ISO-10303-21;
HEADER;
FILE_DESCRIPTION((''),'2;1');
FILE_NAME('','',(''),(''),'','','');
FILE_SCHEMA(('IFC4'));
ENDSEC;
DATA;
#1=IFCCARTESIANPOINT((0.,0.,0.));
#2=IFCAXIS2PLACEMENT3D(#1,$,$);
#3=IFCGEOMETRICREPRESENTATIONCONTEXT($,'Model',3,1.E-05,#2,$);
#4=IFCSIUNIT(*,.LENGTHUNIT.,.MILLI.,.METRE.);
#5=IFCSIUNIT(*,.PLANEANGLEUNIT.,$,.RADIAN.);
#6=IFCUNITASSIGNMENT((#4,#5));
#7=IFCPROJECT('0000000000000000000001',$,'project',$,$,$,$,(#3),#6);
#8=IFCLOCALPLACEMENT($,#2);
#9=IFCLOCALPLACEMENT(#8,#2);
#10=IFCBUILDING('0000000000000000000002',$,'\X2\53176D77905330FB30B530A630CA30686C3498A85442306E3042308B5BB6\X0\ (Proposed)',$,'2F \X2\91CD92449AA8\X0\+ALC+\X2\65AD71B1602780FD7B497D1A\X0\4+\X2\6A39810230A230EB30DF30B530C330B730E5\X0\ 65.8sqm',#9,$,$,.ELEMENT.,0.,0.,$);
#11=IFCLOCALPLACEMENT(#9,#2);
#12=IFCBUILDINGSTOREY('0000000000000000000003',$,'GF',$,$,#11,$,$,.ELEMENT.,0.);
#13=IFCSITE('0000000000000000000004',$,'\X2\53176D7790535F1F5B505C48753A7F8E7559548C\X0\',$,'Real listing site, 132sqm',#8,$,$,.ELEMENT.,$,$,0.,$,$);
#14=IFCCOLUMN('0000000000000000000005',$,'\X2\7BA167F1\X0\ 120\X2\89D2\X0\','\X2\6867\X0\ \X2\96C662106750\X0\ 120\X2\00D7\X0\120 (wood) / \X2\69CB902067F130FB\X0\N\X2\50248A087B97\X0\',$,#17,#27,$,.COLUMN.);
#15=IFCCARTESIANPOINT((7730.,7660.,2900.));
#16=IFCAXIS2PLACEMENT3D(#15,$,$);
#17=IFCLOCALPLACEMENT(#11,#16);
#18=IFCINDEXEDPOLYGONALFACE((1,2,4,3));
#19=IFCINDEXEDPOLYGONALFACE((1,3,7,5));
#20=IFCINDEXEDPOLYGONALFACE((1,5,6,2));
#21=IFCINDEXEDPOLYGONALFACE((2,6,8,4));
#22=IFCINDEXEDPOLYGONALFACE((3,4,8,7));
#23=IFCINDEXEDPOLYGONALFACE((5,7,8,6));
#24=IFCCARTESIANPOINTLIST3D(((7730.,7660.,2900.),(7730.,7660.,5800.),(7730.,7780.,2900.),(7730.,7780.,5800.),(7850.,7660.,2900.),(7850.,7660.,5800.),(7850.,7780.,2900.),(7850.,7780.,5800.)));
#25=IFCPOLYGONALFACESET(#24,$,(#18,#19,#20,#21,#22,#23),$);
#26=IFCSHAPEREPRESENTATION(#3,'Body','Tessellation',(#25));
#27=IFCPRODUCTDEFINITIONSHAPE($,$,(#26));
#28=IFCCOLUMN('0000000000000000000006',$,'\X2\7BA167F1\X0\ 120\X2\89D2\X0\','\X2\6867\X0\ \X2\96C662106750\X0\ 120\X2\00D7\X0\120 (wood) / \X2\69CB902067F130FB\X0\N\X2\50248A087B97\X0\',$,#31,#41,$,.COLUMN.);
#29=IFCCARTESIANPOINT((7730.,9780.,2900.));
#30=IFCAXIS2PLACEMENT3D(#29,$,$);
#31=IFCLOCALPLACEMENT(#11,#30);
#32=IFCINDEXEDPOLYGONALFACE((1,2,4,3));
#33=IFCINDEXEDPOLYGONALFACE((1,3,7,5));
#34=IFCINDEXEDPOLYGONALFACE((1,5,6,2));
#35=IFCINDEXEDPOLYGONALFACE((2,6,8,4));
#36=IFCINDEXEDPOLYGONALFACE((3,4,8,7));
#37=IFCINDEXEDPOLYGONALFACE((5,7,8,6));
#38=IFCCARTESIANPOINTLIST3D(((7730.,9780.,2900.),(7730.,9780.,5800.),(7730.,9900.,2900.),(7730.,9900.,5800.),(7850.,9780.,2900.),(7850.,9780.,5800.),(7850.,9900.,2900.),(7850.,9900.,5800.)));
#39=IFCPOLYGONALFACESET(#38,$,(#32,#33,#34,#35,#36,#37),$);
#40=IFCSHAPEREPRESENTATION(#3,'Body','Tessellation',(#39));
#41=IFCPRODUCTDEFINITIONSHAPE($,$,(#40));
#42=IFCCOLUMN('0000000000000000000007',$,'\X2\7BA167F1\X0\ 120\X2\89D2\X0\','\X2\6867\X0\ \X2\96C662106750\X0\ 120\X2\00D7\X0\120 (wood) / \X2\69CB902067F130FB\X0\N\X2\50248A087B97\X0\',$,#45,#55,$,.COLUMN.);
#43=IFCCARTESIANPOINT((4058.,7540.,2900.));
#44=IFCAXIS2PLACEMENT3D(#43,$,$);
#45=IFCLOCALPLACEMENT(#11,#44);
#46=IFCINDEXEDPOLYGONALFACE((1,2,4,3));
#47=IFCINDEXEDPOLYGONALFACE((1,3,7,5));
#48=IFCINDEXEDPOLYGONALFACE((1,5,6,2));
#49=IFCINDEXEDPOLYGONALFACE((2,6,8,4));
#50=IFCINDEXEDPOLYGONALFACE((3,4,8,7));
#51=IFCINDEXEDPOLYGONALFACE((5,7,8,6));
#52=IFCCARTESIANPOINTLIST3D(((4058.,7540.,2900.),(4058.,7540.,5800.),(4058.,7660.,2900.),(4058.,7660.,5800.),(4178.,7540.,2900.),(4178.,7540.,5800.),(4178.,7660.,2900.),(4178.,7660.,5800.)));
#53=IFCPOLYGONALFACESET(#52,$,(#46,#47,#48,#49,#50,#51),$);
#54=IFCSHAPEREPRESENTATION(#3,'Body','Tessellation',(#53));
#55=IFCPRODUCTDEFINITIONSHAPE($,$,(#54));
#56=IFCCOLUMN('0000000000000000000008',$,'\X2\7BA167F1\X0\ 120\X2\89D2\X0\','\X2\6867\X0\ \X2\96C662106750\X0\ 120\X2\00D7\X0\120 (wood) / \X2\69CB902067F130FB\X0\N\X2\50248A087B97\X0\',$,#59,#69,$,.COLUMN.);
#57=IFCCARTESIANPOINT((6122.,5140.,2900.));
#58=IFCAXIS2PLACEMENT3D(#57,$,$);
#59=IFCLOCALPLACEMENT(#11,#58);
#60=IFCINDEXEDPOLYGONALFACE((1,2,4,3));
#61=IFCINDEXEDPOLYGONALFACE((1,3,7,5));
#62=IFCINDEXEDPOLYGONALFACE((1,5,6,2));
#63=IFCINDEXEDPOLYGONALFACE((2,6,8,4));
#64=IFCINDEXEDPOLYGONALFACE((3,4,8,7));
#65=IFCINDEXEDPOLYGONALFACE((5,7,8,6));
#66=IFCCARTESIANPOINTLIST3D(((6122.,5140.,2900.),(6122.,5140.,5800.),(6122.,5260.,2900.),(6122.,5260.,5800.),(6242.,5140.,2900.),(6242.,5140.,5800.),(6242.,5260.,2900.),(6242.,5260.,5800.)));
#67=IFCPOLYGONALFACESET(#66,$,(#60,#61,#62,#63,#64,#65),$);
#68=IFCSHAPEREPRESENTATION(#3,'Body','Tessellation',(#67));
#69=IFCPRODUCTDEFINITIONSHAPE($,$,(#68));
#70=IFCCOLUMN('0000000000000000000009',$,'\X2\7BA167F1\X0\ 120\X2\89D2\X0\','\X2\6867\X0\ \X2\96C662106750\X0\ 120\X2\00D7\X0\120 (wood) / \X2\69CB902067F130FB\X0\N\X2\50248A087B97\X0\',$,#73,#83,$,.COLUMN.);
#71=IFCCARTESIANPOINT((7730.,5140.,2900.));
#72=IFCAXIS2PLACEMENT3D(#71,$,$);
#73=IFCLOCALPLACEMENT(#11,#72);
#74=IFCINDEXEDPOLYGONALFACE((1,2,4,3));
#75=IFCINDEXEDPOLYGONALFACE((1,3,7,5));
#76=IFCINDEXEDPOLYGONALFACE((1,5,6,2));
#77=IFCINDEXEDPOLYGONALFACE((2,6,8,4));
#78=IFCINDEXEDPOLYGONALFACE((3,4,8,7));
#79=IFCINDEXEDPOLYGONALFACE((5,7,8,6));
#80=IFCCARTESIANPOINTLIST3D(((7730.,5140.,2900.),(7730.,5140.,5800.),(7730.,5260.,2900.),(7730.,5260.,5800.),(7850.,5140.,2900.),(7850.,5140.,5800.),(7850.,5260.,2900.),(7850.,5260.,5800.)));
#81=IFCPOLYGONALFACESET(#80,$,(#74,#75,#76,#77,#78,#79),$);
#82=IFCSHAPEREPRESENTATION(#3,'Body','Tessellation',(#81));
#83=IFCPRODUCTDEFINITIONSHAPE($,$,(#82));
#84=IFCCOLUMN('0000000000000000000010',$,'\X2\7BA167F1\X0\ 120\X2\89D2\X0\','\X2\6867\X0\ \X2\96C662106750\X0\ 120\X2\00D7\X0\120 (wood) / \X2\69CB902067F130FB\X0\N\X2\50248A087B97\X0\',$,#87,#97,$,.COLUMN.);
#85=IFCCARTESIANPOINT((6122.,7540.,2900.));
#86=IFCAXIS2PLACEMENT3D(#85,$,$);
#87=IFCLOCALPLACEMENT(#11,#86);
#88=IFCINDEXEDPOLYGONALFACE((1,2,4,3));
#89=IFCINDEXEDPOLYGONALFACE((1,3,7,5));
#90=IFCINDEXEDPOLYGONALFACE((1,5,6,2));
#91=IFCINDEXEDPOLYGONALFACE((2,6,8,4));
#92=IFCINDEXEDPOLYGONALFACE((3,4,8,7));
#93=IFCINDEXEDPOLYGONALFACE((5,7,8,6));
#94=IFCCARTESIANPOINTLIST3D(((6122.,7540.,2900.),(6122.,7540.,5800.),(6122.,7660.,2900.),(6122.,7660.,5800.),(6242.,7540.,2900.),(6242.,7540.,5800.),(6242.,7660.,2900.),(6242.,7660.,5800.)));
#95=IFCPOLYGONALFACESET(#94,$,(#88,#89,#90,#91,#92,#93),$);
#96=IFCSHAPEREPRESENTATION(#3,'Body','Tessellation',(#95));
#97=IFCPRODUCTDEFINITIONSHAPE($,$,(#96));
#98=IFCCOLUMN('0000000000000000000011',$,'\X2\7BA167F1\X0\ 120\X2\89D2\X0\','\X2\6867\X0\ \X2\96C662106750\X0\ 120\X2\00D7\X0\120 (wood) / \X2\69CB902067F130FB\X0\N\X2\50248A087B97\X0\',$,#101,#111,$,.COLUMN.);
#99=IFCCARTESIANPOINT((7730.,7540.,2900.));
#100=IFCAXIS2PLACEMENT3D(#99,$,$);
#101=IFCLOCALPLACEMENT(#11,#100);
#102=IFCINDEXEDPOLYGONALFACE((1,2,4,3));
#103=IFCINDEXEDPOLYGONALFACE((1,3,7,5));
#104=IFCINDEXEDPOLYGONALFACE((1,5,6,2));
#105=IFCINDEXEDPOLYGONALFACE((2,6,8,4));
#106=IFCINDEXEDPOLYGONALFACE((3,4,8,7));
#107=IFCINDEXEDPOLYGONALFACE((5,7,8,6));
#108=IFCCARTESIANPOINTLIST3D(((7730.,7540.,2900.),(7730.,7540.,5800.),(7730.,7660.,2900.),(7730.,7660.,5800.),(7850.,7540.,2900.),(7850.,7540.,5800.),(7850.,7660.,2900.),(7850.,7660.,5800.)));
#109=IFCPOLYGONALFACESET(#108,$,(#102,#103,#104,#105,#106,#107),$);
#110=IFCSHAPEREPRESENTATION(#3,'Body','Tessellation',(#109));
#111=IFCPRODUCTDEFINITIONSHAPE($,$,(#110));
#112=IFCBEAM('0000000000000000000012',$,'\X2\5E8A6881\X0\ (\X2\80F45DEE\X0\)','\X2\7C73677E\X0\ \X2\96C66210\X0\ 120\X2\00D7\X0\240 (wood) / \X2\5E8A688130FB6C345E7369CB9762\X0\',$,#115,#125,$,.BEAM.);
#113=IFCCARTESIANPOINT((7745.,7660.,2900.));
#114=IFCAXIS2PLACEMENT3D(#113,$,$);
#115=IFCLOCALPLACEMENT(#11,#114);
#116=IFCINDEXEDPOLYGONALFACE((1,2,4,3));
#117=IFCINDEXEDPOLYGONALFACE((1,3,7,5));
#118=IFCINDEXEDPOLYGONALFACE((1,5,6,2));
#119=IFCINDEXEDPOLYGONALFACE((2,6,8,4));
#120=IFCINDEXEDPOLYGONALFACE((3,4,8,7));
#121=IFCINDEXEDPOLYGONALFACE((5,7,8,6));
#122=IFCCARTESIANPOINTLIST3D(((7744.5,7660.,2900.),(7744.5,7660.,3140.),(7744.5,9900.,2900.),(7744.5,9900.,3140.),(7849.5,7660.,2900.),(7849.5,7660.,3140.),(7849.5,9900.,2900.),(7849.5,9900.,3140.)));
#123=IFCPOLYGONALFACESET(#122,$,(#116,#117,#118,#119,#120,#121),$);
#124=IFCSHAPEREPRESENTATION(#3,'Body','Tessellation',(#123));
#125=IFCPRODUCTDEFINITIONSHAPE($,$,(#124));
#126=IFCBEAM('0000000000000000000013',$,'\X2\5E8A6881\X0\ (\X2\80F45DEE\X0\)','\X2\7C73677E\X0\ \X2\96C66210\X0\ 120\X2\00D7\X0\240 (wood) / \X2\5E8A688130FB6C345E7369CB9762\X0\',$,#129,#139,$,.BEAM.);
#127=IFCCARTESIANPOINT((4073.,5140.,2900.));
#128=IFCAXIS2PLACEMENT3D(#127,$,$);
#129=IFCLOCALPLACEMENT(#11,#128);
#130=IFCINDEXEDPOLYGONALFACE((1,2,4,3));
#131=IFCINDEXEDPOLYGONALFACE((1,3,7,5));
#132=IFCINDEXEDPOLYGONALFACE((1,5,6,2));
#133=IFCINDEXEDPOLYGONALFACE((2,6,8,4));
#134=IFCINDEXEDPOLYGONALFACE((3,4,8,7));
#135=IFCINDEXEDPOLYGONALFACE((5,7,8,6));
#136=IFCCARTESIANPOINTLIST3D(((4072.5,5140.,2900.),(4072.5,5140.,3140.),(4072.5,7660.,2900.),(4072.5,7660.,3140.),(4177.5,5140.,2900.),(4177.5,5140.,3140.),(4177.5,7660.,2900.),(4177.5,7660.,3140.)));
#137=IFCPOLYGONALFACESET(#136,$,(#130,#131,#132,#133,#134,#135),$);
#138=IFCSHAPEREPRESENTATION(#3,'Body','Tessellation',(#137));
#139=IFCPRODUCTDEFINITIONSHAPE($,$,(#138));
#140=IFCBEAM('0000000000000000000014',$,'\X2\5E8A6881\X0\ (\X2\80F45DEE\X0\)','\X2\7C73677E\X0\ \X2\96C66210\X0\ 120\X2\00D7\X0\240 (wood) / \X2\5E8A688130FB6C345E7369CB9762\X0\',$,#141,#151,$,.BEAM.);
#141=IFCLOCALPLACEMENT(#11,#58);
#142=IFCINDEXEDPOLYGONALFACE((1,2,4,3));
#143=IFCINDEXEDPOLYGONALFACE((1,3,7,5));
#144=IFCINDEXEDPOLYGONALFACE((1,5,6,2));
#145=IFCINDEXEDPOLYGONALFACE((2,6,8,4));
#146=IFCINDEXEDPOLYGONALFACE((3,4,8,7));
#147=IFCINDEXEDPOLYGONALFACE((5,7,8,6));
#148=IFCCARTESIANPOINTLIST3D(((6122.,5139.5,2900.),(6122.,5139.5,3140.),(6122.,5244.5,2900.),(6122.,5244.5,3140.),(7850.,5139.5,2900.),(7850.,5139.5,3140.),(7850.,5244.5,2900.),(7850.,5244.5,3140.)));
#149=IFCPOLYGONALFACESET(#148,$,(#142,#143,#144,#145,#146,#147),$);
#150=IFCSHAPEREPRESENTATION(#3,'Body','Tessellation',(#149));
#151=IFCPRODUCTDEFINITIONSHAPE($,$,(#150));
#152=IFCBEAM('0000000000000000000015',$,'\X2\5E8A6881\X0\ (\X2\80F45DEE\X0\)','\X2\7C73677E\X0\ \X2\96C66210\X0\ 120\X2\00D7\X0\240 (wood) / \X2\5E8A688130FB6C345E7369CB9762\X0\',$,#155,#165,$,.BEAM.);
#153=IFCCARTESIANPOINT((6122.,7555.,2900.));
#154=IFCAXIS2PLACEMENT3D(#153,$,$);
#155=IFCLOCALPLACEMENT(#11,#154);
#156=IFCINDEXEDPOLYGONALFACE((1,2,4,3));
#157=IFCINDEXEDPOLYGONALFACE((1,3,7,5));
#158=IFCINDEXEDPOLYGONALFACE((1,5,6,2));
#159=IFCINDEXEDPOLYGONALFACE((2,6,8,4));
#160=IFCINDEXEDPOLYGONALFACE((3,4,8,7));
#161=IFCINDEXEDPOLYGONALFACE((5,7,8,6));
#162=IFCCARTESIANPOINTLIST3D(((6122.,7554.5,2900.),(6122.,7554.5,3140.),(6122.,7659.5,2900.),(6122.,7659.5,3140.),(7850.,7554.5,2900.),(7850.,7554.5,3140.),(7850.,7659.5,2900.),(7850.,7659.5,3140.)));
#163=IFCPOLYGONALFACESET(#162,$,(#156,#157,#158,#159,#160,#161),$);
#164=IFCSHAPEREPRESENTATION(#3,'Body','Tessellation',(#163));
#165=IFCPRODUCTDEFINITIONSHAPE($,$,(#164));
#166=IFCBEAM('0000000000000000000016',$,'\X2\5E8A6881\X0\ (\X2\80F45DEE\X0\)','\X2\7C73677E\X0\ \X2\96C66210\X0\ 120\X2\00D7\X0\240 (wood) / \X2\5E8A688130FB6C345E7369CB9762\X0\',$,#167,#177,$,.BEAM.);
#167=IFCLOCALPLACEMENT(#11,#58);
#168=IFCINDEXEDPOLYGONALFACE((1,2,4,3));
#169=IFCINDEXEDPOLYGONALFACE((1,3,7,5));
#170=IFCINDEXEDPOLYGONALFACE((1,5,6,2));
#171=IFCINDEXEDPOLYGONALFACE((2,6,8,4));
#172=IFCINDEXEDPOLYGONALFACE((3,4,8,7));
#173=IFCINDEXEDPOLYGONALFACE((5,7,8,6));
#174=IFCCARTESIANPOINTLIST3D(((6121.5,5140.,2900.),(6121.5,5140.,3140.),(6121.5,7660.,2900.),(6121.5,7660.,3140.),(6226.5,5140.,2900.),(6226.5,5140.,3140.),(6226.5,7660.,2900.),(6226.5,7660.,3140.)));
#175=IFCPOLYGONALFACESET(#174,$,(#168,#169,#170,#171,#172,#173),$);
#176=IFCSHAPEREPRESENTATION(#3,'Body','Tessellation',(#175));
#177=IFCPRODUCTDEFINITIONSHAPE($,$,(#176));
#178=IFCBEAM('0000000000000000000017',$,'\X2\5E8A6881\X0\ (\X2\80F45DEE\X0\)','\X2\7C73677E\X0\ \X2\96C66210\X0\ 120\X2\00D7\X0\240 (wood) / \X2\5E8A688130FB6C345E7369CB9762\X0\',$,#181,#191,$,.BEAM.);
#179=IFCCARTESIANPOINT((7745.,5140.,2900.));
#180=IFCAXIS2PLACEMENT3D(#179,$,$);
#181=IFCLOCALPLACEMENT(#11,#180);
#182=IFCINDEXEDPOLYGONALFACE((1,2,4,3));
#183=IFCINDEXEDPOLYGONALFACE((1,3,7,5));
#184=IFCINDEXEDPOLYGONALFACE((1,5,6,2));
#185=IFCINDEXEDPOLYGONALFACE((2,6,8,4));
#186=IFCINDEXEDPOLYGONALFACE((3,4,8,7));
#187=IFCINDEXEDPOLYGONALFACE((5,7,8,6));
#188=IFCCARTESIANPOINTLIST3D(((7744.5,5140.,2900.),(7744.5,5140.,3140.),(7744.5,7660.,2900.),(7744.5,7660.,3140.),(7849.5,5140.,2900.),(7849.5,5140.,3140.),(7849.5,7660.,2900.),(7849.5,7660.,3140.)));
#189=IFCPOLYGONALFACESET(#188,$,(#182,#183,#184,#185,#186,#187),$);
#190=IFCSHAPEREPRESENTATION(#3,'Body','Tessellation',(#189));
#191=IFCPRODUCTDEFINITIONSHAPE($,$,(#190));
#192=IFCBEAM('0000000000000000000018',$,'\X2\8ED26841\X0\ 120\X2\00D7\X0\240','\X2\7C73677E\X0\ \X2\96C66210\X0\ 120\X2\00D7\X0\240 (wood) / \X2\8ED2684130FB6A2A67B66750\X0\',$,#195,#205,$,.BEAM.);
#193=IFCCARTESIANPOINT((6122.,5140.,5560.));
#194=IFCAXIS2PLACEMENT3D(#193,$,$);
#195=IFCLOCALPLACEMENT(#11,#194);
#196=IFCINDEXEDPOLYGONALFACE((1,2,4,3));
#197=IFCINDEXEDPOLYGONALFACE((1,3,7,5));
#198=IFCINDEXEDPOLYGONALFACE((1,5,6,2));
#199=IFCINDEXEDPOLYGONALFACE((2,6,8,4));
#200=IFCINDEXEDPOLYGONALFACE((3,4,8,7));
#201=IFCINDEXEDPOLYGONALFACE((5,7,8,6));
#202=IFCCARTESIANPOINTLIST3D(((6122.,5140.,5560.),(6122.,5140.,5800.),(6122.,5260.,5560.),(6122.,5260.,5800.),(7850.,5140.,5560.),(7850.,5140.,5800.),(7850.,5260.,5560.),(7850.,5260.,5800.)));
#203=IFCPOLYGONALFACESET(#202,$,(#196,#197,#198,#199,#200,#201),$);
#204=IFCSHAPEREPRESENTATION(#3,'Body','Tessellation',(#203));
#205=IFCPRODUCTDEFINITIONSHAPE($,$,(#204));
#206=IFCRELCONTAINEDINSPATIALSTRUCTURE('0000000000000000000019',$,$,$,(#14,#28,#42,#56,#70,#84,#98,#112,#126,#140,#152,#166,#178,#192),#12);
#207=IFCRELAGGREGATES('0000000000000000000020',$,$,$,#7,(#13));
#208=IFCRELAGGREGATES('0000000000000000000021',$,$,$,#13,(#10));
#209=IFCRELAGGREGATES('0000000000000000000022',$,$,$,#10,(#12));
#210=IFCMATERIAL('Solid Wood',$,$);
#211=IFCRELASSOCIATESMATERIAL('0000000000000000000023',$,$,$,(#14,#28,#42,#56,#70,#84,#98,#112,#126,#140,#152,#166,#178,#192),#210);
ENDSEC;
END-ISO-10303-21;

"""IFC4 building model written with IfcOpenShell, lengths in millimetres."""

from ifc_helpers import new_model, si_unit, frame, frame_2d, origin, place, context, project, spatial, rectangle, extrude, material, element, save


model = new_model("IFC4")

# Units and contexts
model_context = context("Model", 3, precision=1e-05, world=origin())
ifc_project = project(units=[si_unit("LENGTHUNIT", "METRE", prefix="MILLI"), si_unit("PLANEANGLEUNIT", "RADIAN")], contexts=[model_context])

# Site, building, storey
site_placement = place(None, origin())
site = spatial("IfcSite", under=ifc_project, at=site_placement, Name="北海道弟子屈町美留和", ObjectType="Real listing site, 132sqm", CompositionType="ELEMENT", RefElevation=0.0)
building_placement = place(site_placement, origin())
building = spatial("IfcBuilding", under=site, at=building_placement, Name="北海道・サウナと水風呂のある家 (Proposed)", ObjectType="2F 重鉄骨+ALC+断熱性能等級4+樹脂アルミサッシュ 65.8sqm", CompositionType="ELEMENT", ElevationOfRefHeight=0.0, ElevationOfTerrain=0.0)
storey_placement = place(building_placement, origin())
storey = spatial("IfcBuildingStorey", under=building, at=storey_placement, Name="GF", CompositionType="ELEMENT", Elevation=0.0)

# Columns
ifc_material_1 = material(Name="Solid Wood")
column_1_placement = place(storey_placement, frame((7730.0, 7660.0, 2900.0)))
element("IfcColumn", 1, at=column_1_placement, inside=storey, material=ifc_material_1, Name="管柱 120角", Description="桧 集成材 120×120 (wood) / 構造柱・N値計算", PredefinedType="COLUMN", context=model_context, shape_type="SweptSolid", body=[
    extrude(rectangle(XDim=120.0, YDim=120.0, at=frame_2d((60.0, 60.0))), frame((7730.0, 7660.0, 2900.0)), (0.0, 0.0, 1.0), 2900.0),
])
column_2_placement = place(storey_placement, frame((7730.0, 9780.0, 2900.0)))
element("IfcColumn", 2, at=column_2_placement, inside=storey, material=ifc_material_1, Name="管柱 120角", Description="桧 集成材 120×120 (wood) / 構造柱・N値計算", PredefinedType="COLUMN", context=model_context, shape_type="SweptSolid", body=[
    extrude(rectangle(XDim=120.0, YDim=120.0, at=frame_2d((60.0, 60.0))), frame((7730.0, 9780.0, 2900.0)), (0.0, 0.0, 1.0), 2900.0),
])
column_3_placement = place(storey_placement, frame((4058.0, 7540.0, 2900.0)))
element("IfcColumn", 3, at=column_3_placement, inside=storey, material=ifc_material_1, Name="管柱 120角", Description="桧 集成材 120×120 (wood) / 構造柱・N値計算", PredefinedType="COLUMN", context=model_context, shape_type="SweptSolid", body=[
    extrude(rectangle(XDim=120.0, YDim=120.0, at=frame_2d((60.0, 60.0))), frame((4058.0, 7540.0, 2900.0)), (0.0, 0.0, 1.0), 2900.0),
])
column_4_placement = place(storey_placement, frame((6122.0, 5140.0, 2900.0)))
element("IfcColumn", 4, at=column_4_placement, inside=storey, material=ifc_material_1, Name="管柱 120角", Description="桧 集成材 120×120 (wood) / 構造柱・N値計算", PredefinedType="COLUMN", context=model_context, shape_type="SweptSolid", body=[
    extrude(rectangle(XDim=120.0, YDim=120.0, at=frame_2d((60.0, 60.0))), frame((6122.0, 5140.0, 2900.0)), (0.0, 0.0, 1.0), 2900.0),
])
column_5_placement = place(storey_placement, frame((7730.0, 5140.0, 2900.0)))
element("IfcColumn", 5, at=column_5_placement, inside=storey, material=ifc_material_1, Name="管柱 120角", Description="桧 集成材 120×120 (wood) / 構造柱・N値計算", PredefinedType="COLUMN", context=model_context, shape_type="SweptSolid", body=[
    extrude(rectangle(XDim=120.0, YDim=120.0, at=frame_2d((60.0, 60.0))), frame((7730.0, 5140.0, 2900.0)), (0.0, 0.0, 1.0), 2900.0),
])
column_6_placement = place(storey_placement, frame((6122.0, 7540.0, 2900.0)))
element("IfcColumn", 6, at=column_6_placement, inside=storey, material=ifc_material_1, Name="管柱 120角", Description="桧 集成材 120×120 (wood) / 構造柱・N値計算", PredefinedType="COLUMN", context=model_context, shape_type="SweptSolid", body=[
    extrude(rectangle(XDim=120.0, YDim=120.0, at=frame_2d((60.0, 60.0))), frame((6122.0, 7540.0, 2900.0)), (0.0, 0.0, 1.0), 2900.0),
])
column_7_placement = place(storey_placement, frame((7730.0, 7540.0, 2900.0)))
element("IfcColumn", 7, at=column_7_placement, inside=storey, material=ifc_material_1, Name="管柱 120角", Description="桧 集成材 120×120 (wood) / 構造柱・N値計算", PredefinedType="COLUMN", context=model_context, shape_type="SweptSolid", body=[
    extrude(rectangle(XDim=120.0, YDim=120.0, at=frame_2d((60.0, 60.0))), frame((7730.0, 7540.0, 2900.0)), (0.0, 0.0, 1.0), 2900.0),
])

# Beams
beam_1_placement = place(storey_placement, frame((7745.0, 7660.0, 2900.0)))
element("IfcBeam", 8, at=beam_1_placement, inside=storey, material=ifc_material_1, Name="床梁 (胴差)", Description="米松 集成 120×240 (wood) / 床梁・水平構面", PredefinedType="BEAM", context=model_context, shape_type="SweptSolid", body=[
    extrude(rectangle(XDim=105.0, YDim=2240.0, at=frame_2d((52.0, 1120.0))), frame((7745.0, 7660.0, 2900.0)), (0.0, 0.0, 1.0), 240.0),
])
beam_2_placement = place(storey_placement, frame((4073.0, 5140.0, 2900.0)))
element("IfcBeam", 9, at=beam_2_placement, inside=storey, material=ifc_material_1, Name="床梁 (胴差)", Description="米松 集成 120×240 (wood) / 床梁・水平構面", PredefinedType="BEAM", context=model_context, shape_type="SweptSolid", body=[
    extrude(rectangle(XDim=105.0, YDim=2520.0, at=frame_2d((52.0, 1260.0))), frame((4073.0, 5140.0, 2900.0)), (0.0, 0.0, 1.0), 240.0),
])
beam_3_placement = place(storey_placement, frame((6122.0, 5140.0, 2900.0)))
element("IfcBeam", 10, at=beam_3_placement, inside=storey, material=ifc_material_1, Name="床梁 (胴差)", Description="米松 集成 120×240 (wood) / 床梁・水平構面", PredefinedType="BEAM", context=model_context, shape_type="SweptSolid", body=[
    extrude(rectangle(XDim=1728.0, YDim=105.0, at=frame_2d((864.0, 52.0))), frame((6122.0, 5140.0, 2900.0)), (0.0, 0.0, 1.0), 240.0),
])
beam_4_placement = place(storey_placement, frame((6122.0, 7555.0, 2900.0)))
element("IfcBeam", 11, at=beam_4_placement, inside=storey, material=ifc_material_1, Name="床梁 (胴差)", Description="米松 集成 120×240 (wood) / 床梁・水平構面", PredefinedType="BEAM", context=model_context, shape_type="SweptSolid", body=[
    extrude(rectangle(XDim=1728.0, YDim=105.0, at=frame_2d((864.0, 52.0))), frame((6122.0, 7555.0, 2900.0)), (0.0, 0.0, 1.0), 240.0),
])
beam_5_placement = place(storey_placement, frame((6122.0, 5140.0, 2900.0)))
element("IfcBeam", 12, at=beam_5_placement, inside=storey, material=ifc_material_1, Name="床梁 (胴差)", Description="米松 集成 120×240 (wood) / 床梁・水平構面", PredefinedType="BEAM", context=model_context, shape_type="SweptSolid", body=[
    extrude(rectangle(XDim=105.0, YDim=2520.0, at=frame_2d((52.0, 1260.0))), frame((6122.0, 5140.0, 2900.0)), (0.0, 0.0, 1.0), 240.0),
])
beam_6_placement = place(storey_placement, frame((7745.0, 5140.0, 2900.0)))
element("IfcBeam", 13, at=beam_6_placement, inside=storey, material=ifc_material_1, Name="床梁 (胴差)", Description="米松 集成 120×240 (wood) / 床梁・水平構面", PredefinedType="BEAM", context=model_context, shape_type="SweptSolid", body=[
    extrude(rectangle(XDim=105.0, YDim=2520.0, at=frame_2d((52.0, 1260.0))), frame((7745.0, 5140.0, 2900.0)), (0.0, 0.0, 1.0), 240.0),
])
beam_7_placement = place(storey_placement, frame((6122.0, 5140.0, 5560.0)))
element("IfcBeam", 14, at=beam_7_placement, inside=storey, material=ifc_material_1, Name="軒桁 120×240", Description="米松 集成 120×240 (wood) / 軒桁・横架材", PredefinedType="BEAM", context=model_context, shape_type="SweptSolid", body=[
    extrude(rectangle(XDim=1728.0, YDim=120.0, at=frame_2d((864.0, 60.0))), frame((6122.0, 5140.0, 5560.0)), (0.0, 0.0, 1.0), 240.0),
])

save(model, "model.ifc")
